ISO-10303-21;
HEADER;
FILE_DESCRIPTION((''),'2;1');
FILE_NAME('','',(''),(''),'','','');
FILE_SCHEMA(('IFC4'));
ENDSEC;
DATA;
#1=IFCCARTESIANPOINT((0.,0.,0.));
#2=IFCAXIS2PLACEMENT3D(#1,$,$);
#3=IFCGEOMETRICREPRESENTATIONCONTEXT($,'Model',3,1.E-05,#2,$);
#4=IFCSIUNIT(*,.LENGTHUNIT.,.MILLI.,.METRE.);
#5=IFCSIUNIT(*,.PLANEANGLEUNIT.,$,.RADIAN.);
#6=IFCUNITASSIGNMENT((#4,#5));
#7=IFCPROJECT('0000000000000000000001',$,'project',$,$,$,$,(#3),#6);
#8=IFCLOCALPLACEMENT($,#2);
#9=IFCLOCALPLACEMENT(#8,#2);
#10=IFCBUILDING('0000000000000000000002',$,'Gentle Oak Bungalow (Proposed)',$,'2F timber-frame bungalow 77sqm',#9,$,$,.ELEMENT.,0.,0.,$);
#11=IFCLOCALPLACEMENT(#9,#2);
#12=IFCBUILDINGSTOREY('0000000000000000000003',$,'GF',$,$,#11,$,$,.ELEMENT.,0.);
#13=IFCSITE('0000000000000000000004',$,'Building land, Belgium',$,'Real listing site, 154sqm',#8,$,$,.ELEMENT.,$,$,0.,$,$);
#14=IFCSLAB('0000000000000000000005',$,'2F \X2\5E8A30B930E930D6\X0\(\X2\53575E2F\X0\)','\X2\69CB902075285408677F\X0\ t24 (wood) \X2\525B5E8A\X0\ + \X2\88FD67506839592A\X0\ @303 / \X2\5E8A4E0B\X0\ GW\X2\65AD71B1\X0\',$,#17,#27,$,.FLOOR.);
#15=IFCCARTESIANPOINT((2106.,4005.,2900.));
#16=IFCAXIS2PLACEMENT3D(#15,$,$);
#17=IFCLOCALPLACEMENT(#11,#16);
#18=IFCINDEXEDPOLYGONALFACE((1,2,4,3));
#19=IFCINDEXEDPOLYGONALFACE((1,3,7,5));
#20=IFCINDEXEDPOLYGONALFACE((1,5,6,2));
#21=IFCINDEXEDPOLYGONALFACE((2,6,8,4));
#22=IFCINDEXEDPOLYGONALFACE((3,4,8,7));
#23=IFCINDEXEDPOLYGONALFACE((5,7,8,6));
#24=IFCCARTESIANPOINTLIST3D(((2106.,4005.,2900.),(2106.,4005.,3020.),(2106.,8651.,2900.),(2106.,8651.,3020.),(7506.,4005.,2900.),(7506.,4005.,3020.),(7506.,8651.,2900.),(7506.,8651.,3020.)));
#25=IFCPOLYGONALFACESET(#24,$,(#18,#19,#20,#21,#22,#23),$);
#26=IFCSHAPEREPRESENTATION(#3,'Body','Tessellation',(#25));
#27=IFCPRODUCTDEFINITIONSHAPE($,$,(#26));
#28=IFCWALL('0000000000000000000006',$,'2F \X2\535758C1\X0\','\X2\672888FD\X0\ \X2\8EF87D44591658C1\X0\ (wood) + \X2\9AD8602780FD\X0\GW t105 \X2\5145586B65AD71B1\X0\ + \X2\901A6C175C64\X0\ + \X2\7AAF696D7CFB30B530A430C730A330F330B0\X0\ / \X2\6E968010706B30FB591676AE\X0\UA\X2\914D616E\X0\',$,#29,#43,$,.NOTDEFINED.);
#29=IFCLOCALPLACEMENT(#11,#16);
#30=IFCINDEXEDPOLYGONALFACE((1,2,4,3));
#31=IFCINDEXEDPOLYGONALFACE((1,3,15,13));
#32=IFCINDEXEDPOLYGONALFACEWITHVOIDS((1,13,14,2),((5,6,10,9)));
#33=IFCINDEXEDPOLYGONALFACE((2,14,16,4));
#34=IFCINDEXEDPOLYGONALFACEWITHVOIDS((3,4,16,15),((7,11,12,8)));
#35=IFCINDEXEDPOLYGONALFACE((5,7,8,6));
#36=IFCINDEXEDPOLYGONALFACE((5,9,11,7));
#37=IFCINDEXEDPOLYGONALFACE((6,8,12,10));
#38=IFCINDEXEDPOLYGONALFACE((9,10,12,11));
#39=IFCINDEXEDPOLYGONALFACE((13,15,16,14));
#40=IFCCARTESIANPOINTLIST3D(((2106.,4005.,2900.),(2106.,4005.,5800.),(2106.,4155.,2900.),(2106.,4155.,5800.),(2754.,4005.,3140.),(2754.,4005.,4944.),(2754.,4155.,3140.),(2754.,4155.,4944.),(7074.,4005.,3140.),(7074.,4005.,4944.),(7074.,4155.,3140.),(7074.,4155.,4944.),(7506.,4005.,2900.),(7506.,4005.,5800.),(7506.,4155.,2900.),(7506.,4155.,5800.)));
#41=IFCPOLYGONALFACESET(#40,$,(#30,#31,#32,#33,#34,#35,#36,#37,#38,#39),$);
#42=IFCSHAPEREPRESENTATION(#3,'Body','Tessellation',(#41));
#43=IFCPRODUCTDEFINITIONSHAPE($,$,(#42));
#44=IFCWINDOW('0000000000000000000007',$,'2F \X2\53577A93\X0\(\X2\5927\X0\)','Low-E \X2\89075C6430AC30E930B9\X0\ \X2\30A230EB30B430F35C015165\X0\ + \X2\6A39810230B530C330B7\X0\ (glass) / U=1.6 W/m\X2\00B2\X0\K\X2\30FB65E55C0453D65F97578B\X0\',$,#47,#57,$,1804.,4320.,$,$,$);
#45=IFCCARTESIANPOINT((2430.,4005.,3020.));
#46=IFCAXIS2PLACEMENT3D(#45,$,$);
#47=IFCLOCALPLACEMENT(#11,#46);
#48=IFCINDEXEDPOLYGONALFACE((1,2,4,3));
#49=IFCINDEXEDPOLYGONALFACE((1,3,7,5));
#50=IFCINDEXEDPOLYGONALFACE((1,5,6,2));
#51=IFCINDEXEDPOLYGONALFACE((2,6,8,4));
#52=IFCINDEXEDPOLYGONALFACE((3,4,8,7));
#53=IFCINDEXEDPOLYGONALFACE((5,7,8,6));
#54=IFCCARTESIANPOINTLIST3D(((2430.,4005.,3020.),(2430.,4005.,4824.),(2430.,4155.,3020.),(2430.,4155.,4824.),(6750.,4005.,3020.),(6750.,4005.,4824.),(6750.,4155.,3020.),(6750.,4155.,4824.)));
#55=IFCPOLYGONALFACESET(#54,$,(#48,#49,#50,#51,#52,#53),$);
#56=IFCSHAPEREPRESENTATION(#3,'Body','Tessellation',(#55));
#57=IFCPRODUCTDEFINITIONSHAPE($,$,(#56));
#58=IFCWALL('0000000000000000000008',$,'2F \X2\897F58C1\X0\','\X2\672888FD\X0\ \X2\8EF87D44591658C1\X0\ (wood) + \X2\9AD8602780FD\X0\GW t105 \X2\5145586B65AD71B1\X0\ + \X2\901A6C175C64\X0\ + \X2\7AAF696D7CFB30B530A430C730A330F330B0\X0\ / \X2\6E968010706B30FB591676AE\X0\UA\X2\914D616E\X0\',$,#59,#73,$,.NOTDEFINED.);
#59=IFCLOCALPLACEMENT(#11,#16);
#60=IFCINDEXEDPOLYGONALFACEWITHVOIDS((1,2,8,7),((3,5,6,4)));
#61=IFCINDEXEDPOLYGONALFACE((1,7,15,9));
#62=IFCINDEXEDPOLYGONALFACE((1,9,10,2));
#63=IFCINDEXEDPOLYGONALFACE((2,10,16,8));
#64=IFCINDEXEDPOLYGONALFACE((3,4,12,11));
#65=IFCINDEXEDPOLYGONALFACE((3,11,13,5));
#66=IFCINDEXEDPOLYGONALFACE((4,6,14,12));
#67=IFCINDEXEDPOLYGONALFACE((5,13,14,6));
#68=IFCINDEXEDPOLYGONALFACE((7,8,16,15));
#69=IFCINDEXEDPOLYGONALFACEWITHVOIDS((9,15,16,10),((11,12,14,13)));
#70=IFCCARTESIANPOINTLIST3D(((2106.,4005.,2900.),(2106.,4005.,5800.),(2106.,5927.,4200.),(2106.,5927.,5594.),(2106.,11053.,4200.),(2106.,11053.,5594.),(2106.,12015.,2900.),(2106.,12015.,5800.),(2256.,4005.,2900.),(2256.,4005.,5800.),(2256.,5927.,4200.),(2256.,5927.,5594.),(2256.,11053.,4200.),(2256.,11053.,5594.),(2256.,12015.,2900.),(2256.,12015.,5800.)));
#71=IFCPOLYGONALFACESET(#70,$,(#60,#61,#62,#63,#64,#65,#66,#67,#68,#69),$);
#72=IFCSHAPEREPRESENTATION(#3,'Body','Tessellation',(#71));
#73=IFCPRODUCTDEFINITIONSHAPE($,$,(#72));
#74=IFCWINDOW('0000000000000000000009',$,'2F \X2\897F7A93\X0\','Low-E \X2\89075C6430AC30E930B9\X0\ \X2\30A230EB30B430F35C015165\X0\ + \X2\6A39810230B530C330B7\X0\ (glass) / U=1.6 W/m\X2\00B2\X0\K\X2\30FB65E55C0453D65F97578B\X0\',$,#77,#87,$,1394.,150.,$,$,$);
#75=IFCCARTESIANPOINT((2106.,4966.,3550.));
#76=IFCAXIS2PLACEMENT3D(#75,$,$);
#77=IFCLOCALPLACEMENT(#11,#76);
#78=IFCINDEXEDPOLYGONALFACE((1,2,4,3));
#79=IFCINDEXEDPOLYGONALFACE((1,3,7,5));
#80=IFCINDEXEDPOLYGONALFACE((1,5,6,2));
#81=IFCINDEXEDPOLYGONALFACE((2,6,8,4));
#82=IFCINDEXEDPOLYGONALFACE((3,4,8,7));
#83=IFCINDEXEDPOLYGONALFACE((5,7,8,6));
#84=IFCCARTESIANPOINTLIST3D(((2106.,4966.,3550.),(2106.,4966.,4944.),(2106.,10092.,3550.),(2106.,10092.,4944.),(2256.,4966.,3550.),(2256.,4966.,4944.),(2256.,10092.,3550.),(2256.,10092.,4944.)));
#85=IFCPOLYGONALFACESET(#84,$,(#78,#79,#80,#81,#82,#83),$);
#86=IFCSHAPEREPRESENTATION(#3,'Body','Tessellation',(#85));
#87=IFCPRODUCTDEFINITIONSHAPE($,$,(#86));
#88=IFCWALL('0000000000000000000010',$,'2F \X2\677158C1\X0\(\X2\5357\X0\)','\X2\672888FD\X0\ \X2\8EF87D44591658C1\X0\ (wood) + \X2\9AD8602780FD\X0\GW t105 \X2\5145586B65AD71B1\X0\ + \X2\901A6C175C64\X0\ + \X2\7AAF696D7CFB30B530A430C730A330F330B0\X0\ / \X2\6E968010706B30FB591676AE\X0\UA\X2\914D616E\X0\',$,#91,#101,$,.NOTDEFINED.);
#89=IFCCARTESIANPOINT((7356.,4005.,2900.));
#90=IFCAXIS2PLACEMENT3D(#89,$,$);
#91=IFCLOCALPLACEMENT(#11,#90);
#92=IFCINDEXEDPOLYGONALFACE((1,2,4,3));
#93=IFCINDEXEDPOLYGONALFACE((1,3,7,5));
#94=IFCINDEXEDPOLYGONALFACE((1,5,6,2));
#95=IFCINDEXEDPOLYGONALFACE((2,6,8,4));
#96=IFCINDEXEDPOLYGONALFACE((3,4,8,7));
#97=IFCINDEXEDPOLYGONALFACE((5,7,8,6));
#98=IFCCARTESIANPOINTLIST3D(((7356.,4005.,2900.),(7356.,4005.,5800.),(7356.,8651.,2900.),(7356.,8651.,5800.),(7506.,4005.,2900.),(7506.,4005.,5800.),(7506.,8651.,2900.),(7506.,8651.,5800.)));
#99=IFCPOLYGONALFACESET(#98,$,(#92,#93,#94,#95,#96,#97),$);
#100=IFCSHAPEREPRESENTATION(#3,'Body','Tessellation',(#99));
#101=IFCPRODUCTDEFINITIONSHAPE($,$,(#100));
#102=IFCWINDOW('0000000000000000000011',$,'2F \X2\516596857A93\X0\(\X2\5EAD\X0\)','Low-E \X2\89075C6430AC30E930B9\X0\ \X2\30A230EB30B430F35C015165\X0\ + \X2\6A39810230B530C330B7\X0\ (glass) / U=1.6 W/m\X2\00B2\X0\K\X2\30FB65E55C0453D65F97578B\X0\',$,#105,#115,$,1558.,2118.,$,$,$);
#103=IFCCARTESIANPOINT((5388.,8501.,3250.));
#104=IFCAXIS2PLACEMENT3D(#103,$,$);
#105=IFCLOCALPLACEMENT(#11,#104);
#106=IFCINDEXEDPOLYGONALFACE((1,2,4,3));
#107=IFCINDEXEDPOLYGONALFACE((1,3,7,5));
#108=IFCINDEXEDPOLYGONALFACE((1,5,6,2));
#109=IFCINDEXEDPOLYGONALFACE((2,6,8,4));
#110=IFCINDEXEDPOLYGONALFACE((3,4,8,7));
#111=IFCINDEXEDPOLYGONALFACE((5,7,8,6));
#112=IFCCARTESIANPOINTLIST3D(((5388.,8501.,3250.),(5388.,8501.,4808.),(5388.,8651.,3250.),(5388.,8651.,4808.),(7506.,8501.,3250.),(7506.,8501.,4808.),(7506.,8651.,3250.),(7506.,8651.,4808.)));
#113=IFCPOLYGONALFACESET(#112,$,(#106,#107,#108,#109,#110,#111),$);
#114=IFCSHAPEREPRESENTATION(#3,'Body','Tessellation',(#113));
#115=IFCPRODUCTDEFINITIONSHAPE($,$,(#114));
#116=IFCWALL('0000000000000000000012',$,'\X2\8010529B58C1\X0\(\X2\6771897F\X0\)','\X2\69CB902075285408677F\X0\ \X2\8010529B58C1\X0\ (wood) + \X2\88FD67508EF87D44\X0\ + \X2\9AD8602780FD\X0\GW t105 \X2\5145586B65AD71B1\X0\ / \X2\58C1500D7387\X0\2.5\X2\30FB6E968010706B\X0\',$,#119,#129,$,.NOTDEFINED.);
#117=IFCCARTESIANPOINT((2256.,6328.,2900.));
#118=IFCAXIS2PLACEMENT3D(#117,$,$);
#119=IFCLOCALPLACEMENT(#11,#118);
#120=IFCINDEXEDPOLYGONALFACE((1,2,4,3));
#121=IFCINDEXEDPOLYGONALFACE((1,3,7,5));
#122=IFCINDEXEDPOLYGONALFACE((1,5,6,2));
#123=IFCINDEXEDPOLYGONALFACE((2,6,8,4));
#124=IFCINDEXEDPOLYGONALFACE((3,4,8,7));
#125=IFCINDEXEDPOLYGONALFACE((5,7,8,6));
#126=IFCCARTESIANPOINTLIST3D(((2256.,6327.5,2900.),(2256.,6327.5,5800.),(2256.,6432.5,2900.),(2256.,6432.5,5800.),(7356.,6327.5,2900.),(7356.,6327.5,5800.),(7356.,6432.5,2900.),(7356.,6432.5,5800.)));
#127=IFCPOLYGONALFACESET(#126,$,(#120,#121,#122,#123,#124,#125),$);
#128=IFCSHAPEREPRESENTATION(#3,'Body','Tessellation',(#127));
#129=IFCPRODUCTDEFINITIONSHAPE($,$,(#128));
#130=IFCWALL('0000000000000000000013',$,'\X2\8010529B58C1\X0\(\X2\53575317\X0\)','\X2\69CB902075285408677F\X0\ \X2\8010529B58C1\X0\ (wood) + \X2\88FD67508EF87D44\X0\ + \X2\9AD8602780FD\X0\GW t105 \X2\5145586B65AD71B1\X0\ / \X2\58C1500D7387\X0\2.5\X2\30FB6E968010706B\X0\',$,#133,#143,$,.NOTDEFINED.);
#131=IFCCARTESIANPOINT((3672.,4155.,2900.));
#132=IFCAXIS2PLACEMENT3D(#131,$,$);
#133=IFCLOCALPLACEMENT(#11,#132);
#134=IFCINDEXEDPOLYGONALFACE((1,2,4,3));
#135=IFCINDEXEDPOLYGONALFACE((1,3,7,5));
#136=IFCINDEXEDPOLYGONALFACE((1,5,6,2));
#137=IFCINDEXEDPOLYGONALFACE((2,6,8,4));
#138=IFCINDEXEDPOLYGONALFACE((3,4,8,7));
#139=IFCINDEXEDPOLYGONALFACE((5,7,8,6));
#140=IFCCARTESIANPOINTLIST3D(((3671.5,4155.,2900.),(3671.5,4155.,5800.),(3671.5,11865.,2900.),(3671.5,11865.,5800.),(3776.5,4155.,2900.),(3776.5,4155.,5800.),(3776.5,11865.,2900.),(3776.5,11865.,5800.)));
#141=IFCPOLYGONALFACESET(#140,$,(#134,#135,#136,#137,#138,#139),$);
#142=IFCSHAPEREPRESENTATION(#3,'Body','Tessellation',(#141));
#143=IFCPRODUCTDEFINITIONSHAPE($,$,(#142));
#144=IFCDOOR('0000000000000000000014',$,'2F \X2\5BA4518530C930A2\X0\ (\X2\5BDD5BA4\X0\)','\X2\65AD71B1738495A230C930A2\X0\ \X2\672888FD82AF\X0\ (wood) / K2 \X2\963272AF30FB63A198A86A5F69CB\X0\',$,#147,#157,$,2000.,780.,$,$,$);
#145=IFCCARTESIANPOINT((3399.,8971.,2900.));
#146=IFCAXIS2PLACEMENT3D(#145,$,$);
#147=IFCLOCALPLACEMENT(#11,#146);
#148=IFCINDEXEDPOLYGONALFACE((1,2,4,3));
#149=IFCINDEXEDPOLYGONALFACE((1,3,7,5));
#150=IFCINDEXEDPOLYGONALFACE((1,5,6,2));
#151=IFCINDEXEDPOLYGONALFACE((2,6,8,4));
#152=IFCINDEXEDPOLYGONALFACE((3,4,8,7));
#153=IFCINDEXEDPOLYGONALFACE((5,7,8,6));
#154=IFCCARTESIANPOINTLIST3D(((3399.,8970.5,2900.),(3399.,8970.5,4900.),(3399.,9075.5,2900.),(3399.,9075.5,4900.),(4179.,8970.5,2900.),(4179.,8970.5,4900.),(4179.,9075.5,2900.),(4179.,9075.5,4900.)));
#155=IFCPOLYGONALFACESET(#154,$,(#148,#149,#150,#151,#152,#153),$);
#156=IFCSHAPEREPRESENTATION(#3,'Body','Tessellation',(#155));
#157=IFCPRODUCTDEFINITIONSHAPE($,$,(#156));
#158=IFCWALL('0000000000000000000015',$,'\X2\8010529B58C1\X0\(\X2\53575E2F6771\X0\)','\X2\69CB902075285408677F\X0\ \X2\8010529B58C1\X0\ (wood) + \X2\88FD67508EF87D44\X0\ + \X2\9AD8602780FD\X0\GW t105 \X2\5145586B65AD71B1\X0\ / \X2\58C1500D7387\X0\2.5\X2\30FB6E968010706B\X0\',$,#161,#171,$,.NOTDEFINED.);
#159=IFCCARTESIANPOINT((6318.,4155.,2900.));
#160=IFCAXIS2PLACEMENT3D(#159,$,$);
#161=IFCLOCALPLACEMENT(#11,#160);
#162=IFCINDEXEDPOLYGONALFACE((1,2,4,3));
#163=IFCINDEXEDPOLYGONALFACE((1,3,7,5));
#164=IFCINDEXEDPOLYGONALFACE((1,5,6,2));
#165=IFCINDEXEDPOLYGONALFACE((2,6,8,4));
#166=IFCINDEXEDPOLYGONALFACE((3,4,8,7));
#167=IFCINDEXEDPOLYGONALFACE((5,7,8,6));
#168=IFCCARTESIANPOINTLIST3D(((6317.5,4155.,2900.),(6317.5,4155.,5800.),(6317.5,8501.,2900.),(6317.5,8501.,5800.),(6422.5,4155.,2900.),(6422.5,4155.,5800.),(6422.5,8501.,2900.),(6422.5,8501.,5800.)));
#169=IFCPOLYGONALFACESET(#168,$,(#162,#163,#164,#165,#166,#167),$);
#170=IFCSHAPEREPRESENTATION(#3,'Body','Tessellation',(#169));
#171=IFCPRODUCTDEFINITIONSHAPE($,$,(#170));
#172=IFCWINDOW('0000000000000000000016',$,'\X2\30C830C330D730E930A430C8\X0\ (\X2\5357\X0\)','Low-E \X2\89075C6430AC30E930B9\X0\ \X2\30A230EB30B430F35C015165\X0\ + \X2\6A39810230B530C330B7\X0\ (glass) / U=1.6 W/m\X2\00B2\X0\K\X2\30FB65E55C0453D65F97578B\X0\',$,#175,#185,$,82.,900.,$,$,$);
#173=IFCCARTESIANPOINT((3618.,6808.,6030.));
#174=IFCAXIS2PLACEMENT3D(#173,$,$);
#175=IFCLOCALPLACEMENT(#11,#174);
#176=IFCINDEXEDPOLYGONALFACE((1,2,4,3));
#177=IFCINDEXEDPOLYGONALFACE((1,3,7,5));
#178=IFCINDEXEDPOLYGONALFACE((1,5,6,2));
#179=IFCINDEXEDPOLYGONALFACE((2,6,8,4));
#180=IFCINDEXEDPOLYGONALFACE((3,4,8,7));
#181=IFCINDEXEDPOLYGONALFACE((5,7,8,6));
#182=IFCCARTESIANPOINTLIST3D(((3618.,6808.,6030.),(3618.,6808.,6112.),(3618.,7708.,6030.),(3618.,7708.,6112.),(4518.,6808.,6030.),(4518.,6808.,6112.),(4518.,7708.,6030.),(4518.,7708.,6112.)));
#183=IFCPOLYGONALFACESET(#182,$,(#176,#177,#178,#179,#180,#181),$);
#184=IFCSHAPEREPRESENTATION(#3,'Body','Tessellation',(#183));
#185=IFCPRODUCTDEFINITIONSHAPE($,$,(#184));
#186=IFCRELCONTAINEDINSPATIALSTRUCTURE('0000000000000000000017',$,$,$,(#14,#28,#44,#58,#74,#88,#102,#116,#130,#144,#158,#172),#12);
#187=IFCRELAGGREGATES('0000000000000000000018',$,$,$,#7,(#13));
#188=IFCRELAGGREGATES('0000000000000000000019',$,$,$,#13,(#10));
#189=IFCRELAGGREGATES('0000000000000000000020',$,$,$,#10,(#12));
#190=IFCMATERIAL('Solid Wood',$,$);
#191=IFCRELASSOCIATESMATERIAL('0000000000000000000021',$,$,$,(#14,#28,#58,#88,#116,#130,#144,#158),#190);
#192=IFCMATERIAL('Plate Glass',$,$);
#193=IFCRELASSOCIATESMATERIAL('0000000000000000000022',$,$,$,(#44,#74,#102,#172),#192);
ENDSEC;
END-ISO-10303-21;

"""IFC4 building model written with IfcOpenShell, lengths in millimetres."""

from ifc_helpers import new_model, si_unit, frame, frame_2d, origin, place, context, project, spatial, rectangle, extrude, material, element, fill, save


model = new_model("IFC4")

# Units and contexts
model_context = context("Model", 3, precision=1e-05, world=origin())
ifc_project = project(units=[si_unit("LENGTHUNIT", "METRE", prefix="MILLI"), si_unit("PLANEANGLEUNIT", "RADIAN")], contexts=[model_context])

# Site, building, storey
site_placement = place(None, origin())
site = spatial("IfcSite", under=ifc_project, at=site_placement, Name="Building land, Belgium", ObjectType="Real listing site, 154sqm", CompositionType="ELEMENT", RefElevation=0.0)
building_placement = place(site_placement, origin())
building = spatial("IfcBuilding", under=site, at=building_placement, Name="Gentle Oak Bungalow (Proposed)", ObjectType="2F timber-frame bungalow 77sqm", CompositionType="ELEMENT", ElevationOfRefHeight=0.0, ElevationOfTerrain=0.0)
storey_placement = place(building_placement, origin())
storey = spatial("IfcBuildingStorey", under=building, at=storey_placement, Name="GF", CompositionType="ELEMENT", Elevation=0.0)

# Slab
ifc_material_1 = material(Name="Solid Wood")
slab_placement = place(storey_placement, frame((2106.0, 4005.0, 2900.0)))
element("IfcSlab", 1, at=slab_placement, inside=storey, material=ifc_material_1, Name="2F 床スラブ(南帯)", Description="構造用合板 t24 (wood) 剛床 + 製材根太 @303 / 床下 GW断熱", PredefinedType="FLOOR", context=model_context, shape_type="SweptSolid", body=[
    extrude(rectangle(XDim=5400.0, YDim=4646.0, at=frame_2d((2700.0, 2323.0))), frame((2106.0, 4005.0, 2900.0)), (0.0, 0.0, 1.0), 120.0),
])

# Walls, openings, windows
wall_1_placement = place(storey_placement, frame((2106.0, 4005.0, 2900.0)))
wall_1 = element("IfcWall", 2, at=wall_1_placement, inside=storey, material=ifc_material_1, Name="2F 南壁", Description="木製 軸組外壁 (wood) + 高性能GW t105 充填断熱 + 通気層 + 窯業系サイディング / 準耐火・外皮UA配慮", PredefinedType="NOTDEFINED", context=model_context, shape_type="SweptSolid", body=[
    extrude(rectangle(XDim=5400.0, YDim=150.0, at=frame_2d((2700.0, 75.0))), frame((2106.0, 4005.0, 2900.0)), (0.0, 0.0, 1.0), 2900.0),
])
opening_1_placement = place(storey_placement, frame((2430.0, 4005.0, 3020.0)))
opening_1 = element("IfcOpeningElement", 3, at=opening_1_placement, cuts=wall_1, PredefinedType="NOTDEFINED", context=model_context, shape_type="SweptSolid", body=[
    extrude(rectangle(XDim=4320.0, YDim=150.0, at=frame_2d((2160.0, 75.0))), frame((2430.0, 4005.0, 3020.0)), (0.0, 0.0, 1.0), 1804.0),
])
ifc_material_2 = material(Name="Plate Glass")
window_1_placement = place(storey_placement, frame((2430.0, 4005.0, 3020.0)))
window_1 = element("IfcWindow", 4, at=window_1_placement, inside=storey, material=ifc_material_2, Name="2F 南窓(大)", Description="Low-E 複層ガラス アルゴン封入 + 樹脂サッシ (glass) / U=1.6 W/m²K・日射取得型", OverallHeight=1804.0, OverallWidth=4320.0, context=model_context, shape_type="SweptSolid", body=[
    extrude(rectangle(XDim=4320.0, YDim=150.0, at=frame_2d((2160.0, 75.0))), frame((2430.0, 4005.0, 3020.0)), (0.0, 0.0, 1.0), 1804.0),
])
fill(opening_1, window_1)
wall_2_placement = place(storey_placement, frame((2106.0, 4005.0, 2900.0)))
wall_2 = element("IfcWall", 5, at=wall_2_placement, inside=storey, material=ifc_material_1, Name="2F 西壁", Description="木製 軸組外壁 (wood) + 高性能GW t105 充填断熱 + 通気層 + 窯業系サイディング / 準耐火・外皮UA配慮", PredefinedType="NOTDEFINED", context=model_context, shape_type="SweptSolid", body=[
    extrude(rectangle(XDim=150.0, YDim=8010.0, at=frame_2d((75.0, 4005.0))), frame((2106.0, 4005.0, 2900.0)), (0.0, 0.0, 1.0), 2900.0),
])
opening_2_placement = place(storey_placement, frame((2106.0, 4966.0, 3550.0)))
opening_2 = element("IfcOpeningElement", 6, at=opening_2_placement, cuts=wall_2, PredefinedType="NOTDEFINED", context=model_context, shape_type="SweptSolid", body=[
    extrude(rectangle(XDim=150.0, YDim=5126.0, at=frame_2d((75.0, 2563.0))), frame((2106.0, 4966.0, 3550.0)), (0.0, 0.0, 1.0), 1394.0),
])
window_2_placement = place(storey_placement, frame((2106.0, 4966.0, 3550.0)))
window_2 = element("IfcWindow", 7, at=window_2_placement, inside=storey, material=ifc_material_2, Name="2F 西窓", Description="Low-E 複層ガラス アルゴン封入 + 樹脂サッシ (glass) / U=1.6 W/m²K・日射取得型", OverallHeight=1394.0, OverallWidth=150.0, context=model_context, shape_type="SweptSolid", body=[
    extrude(rectangle(XDim=150.0, YDim=5126.0, at=frame_2d((75.0, 2563.0))), frame((2106.0, 4966.0, 3550.0)), (0.0, 0.0, 1.0), 1394.0),
])
fill(opening_2, window_2)
wall_3_placement = place(storey_placement, frame((7356.0, 4005.0, 2900.0)))
wall_3 = element("IfcWall", 8, at=wall_3_placement, inside=storey, material=ifc_material_1, Name="2F 東壁(南)", Description="木製 軸組外壁 (wood) + 高性能GW t105 充填断熱 + 通気層 + 窯業系サイディング / 準耐火・外皮UA配慮", PredefinedType="NOTDEFINED", context=model_context, shape_type="SweptSolid", body=[
    extrude(rectangle(XDim=150.0, YDim=4646.0, at=frame_2d((75.0, 2323.0))), frame((7356.0, 4005.0, 2900.0)), (0.0, 0.0, 1.0), 2900.0),
])
opening_3_placement = place(storey_placement, frame((5388.0, 8501.0, 3250.0)))
opening_3 = element("IfcOpeningElement", 9, at=opening_3_placement, cuts=wall_3, PredefinedType="NOTDEFINED", context=model_context, shape_type="SweptSolid", body=[
    extrude(rectangle(XDim=2118.0, YDim=150.0, at=frame_2d((1059.0, 75.0))), frame((5388.0, 8501.0, 3250.0)), (0.0, 0.0, 1.0), 1558.0),
])
window_3_placement = place(storey_placement, frame((5388.0, 8501.0, 3250.0)))
window_3 = element("IfcWindow", 10, at=window_3_placement, inside=storey, material=ifc_material_2, Name="2F 入隅窓(庭)", Description="Low-E 複層ガラス アルゴン封入 + 樹脂サッシ (glass) / U=1.6 W/m²K・日射取得型", OverallHeight=1558.0, OverallWidth=2118.0, context=model_context, shape_type="SweptSolid", body=[
    extrude(rectangle(XDim=2118.0, YDim=150.0, at=frame_2d((1059.0, 75.0))), frame((5388.0, 8501.0, 3250.0)), (0.0, 0.0, 1.0), 1558.0),
])
fill(opening_3, window_3)

# Wall
wall_4_placement = place(storey_placement, frame((2256.0, 6328.0, 2900.0)))
element("IfcWall", 11, at=wall_4_placement, inside=storey, material=ifc_material_1, Name="耐力壁(東西)", Description="構造用合板 耐力壁 (wood) + 製材軸組 + 高性能GW t105 充填断熱 / 壁倍率2.5・準耐火", PredefinedType="NOTDEFINED", context=model_context, shape_type="SweptSolid", body=[
    extrude(rectangle(XDim=5100.0, YDim=105.0, at=frame_2d((2550.0, 52.0))), frame((2256.0, 6328.0, 2900.0)), (0.0, 0.0, 1.0), 2900.0),
])

# Wall, opening, door
wall_5_placement = place(storey_placement, frame((3672.0, 4155.0, 2900.0)))
wall_5 = element("IfcWall", 12, at=wall_5_placement, inside=storey, material=ifc_material_1, Name="耐力壁(南北)", Description="構造用合板 耐力壁 (wood) + 製材軸組 + 高性能GW t105 充填断熱 / 壁倍率2.5・準耐火", PredefinedType="NOTDEFINED", context=model_context, shape_type="SweptSolid", body=[
    extrude(rectangle(XDim=105.0, YDim=7710.0, at=frame_2d((52.0, 3855.0))), frame((3672.0, 4155.0, 2900.0)), (0.0, 0.0, 1.0), 2900.0),
])
opening_4_placement = place(storey_placement, frame((3399.0, 8971.0, 2900.0)))
opening_4 = element("IfcOpeningElement", 13, at=opening_4_placement, cuts=wall_5, PredefinedType="NOTDEFINED", context=model_context, shape_type="SweptSolid", body=[
    extrude(rectangle(XDim=780.0, YDim=105.0, at=frame_2d((390.0, 52.0))), frame((3399.0, 8971.0, 2900.0)), (0.0, 0.0, 1.0), 2000.0),
])
door_placement = place(storey_placement, frame((3399.0, 8971.0, 2900.0)))
door = element("IfcDoor", 14, at=door_placement, inside=storey, material=ifc_material_1, Name="2F 室内ドア (寝室)", Description="断熱玄関ドア 木製芯 (wood) / K2 防犯・採風機構", OverallHeight=2000.0, OverallWidth=780.0, context=model_context, shape_type="SweptSolid", body=[
    extrude(rectangle(XDim=780.0, YDim=105.0, at=frame_2d((390.0, 52.0))), frame((3399.0, 8971.0, 2900.0)), (0.0, 0.0, 1.0), 2000.0),
])
fill(opening_4, door)

# Wall
wall_6_placement = place(storey_placement, frame((6318.0, 4155.0, 2900.0)))
element("IfcWall", 15, at=wall_6_placement, inside=storey, material=ifc_material_1, Name="耐力壁(南帯東)", Description="構造用合板 耐力壁 (wood) + 製材軸組 + 高性能GW t105 充填断熱 / 壁倍率2.5・準耐火", PredefinedType="NOTDEFINED", context=model_context, shape_type="SweptSolid", body=[
    extrude(rectangle(XDim=105.0, YDim=4346.0, at=frame_2d((52.0, 2173.0))), frame((6318.0, 4155.0, 2900.0)), (0.0, 0.0, 1.0), 2900.0),
])

# Window
window_4_placement = place(storey_placement, frame((3618.0, 6808.0, 6030.0)))
element("IfcWindow", 16, at=window_4_placement, inside=storey, material=ifc_material_2, Name="トップライト (南)", Description="Low-E 複層ガラス アルゴン封入 + 樹脂サッシ (glass) / U=1.6 W/m²K・日射取得型", OverallHeight=82.0, OverallWidth=900.0, context=model_context, shape_type="SweptSolid", body=[
    extrude(rectangle(XDim=900.0, YDim=900.0, at=frame_2d((450.0, 450.0))), frame((3618.0, 6808.0, 6030.0)), (0.0, 0.0, 1.0), 82.0),
])

save(model, "model.ifc")
